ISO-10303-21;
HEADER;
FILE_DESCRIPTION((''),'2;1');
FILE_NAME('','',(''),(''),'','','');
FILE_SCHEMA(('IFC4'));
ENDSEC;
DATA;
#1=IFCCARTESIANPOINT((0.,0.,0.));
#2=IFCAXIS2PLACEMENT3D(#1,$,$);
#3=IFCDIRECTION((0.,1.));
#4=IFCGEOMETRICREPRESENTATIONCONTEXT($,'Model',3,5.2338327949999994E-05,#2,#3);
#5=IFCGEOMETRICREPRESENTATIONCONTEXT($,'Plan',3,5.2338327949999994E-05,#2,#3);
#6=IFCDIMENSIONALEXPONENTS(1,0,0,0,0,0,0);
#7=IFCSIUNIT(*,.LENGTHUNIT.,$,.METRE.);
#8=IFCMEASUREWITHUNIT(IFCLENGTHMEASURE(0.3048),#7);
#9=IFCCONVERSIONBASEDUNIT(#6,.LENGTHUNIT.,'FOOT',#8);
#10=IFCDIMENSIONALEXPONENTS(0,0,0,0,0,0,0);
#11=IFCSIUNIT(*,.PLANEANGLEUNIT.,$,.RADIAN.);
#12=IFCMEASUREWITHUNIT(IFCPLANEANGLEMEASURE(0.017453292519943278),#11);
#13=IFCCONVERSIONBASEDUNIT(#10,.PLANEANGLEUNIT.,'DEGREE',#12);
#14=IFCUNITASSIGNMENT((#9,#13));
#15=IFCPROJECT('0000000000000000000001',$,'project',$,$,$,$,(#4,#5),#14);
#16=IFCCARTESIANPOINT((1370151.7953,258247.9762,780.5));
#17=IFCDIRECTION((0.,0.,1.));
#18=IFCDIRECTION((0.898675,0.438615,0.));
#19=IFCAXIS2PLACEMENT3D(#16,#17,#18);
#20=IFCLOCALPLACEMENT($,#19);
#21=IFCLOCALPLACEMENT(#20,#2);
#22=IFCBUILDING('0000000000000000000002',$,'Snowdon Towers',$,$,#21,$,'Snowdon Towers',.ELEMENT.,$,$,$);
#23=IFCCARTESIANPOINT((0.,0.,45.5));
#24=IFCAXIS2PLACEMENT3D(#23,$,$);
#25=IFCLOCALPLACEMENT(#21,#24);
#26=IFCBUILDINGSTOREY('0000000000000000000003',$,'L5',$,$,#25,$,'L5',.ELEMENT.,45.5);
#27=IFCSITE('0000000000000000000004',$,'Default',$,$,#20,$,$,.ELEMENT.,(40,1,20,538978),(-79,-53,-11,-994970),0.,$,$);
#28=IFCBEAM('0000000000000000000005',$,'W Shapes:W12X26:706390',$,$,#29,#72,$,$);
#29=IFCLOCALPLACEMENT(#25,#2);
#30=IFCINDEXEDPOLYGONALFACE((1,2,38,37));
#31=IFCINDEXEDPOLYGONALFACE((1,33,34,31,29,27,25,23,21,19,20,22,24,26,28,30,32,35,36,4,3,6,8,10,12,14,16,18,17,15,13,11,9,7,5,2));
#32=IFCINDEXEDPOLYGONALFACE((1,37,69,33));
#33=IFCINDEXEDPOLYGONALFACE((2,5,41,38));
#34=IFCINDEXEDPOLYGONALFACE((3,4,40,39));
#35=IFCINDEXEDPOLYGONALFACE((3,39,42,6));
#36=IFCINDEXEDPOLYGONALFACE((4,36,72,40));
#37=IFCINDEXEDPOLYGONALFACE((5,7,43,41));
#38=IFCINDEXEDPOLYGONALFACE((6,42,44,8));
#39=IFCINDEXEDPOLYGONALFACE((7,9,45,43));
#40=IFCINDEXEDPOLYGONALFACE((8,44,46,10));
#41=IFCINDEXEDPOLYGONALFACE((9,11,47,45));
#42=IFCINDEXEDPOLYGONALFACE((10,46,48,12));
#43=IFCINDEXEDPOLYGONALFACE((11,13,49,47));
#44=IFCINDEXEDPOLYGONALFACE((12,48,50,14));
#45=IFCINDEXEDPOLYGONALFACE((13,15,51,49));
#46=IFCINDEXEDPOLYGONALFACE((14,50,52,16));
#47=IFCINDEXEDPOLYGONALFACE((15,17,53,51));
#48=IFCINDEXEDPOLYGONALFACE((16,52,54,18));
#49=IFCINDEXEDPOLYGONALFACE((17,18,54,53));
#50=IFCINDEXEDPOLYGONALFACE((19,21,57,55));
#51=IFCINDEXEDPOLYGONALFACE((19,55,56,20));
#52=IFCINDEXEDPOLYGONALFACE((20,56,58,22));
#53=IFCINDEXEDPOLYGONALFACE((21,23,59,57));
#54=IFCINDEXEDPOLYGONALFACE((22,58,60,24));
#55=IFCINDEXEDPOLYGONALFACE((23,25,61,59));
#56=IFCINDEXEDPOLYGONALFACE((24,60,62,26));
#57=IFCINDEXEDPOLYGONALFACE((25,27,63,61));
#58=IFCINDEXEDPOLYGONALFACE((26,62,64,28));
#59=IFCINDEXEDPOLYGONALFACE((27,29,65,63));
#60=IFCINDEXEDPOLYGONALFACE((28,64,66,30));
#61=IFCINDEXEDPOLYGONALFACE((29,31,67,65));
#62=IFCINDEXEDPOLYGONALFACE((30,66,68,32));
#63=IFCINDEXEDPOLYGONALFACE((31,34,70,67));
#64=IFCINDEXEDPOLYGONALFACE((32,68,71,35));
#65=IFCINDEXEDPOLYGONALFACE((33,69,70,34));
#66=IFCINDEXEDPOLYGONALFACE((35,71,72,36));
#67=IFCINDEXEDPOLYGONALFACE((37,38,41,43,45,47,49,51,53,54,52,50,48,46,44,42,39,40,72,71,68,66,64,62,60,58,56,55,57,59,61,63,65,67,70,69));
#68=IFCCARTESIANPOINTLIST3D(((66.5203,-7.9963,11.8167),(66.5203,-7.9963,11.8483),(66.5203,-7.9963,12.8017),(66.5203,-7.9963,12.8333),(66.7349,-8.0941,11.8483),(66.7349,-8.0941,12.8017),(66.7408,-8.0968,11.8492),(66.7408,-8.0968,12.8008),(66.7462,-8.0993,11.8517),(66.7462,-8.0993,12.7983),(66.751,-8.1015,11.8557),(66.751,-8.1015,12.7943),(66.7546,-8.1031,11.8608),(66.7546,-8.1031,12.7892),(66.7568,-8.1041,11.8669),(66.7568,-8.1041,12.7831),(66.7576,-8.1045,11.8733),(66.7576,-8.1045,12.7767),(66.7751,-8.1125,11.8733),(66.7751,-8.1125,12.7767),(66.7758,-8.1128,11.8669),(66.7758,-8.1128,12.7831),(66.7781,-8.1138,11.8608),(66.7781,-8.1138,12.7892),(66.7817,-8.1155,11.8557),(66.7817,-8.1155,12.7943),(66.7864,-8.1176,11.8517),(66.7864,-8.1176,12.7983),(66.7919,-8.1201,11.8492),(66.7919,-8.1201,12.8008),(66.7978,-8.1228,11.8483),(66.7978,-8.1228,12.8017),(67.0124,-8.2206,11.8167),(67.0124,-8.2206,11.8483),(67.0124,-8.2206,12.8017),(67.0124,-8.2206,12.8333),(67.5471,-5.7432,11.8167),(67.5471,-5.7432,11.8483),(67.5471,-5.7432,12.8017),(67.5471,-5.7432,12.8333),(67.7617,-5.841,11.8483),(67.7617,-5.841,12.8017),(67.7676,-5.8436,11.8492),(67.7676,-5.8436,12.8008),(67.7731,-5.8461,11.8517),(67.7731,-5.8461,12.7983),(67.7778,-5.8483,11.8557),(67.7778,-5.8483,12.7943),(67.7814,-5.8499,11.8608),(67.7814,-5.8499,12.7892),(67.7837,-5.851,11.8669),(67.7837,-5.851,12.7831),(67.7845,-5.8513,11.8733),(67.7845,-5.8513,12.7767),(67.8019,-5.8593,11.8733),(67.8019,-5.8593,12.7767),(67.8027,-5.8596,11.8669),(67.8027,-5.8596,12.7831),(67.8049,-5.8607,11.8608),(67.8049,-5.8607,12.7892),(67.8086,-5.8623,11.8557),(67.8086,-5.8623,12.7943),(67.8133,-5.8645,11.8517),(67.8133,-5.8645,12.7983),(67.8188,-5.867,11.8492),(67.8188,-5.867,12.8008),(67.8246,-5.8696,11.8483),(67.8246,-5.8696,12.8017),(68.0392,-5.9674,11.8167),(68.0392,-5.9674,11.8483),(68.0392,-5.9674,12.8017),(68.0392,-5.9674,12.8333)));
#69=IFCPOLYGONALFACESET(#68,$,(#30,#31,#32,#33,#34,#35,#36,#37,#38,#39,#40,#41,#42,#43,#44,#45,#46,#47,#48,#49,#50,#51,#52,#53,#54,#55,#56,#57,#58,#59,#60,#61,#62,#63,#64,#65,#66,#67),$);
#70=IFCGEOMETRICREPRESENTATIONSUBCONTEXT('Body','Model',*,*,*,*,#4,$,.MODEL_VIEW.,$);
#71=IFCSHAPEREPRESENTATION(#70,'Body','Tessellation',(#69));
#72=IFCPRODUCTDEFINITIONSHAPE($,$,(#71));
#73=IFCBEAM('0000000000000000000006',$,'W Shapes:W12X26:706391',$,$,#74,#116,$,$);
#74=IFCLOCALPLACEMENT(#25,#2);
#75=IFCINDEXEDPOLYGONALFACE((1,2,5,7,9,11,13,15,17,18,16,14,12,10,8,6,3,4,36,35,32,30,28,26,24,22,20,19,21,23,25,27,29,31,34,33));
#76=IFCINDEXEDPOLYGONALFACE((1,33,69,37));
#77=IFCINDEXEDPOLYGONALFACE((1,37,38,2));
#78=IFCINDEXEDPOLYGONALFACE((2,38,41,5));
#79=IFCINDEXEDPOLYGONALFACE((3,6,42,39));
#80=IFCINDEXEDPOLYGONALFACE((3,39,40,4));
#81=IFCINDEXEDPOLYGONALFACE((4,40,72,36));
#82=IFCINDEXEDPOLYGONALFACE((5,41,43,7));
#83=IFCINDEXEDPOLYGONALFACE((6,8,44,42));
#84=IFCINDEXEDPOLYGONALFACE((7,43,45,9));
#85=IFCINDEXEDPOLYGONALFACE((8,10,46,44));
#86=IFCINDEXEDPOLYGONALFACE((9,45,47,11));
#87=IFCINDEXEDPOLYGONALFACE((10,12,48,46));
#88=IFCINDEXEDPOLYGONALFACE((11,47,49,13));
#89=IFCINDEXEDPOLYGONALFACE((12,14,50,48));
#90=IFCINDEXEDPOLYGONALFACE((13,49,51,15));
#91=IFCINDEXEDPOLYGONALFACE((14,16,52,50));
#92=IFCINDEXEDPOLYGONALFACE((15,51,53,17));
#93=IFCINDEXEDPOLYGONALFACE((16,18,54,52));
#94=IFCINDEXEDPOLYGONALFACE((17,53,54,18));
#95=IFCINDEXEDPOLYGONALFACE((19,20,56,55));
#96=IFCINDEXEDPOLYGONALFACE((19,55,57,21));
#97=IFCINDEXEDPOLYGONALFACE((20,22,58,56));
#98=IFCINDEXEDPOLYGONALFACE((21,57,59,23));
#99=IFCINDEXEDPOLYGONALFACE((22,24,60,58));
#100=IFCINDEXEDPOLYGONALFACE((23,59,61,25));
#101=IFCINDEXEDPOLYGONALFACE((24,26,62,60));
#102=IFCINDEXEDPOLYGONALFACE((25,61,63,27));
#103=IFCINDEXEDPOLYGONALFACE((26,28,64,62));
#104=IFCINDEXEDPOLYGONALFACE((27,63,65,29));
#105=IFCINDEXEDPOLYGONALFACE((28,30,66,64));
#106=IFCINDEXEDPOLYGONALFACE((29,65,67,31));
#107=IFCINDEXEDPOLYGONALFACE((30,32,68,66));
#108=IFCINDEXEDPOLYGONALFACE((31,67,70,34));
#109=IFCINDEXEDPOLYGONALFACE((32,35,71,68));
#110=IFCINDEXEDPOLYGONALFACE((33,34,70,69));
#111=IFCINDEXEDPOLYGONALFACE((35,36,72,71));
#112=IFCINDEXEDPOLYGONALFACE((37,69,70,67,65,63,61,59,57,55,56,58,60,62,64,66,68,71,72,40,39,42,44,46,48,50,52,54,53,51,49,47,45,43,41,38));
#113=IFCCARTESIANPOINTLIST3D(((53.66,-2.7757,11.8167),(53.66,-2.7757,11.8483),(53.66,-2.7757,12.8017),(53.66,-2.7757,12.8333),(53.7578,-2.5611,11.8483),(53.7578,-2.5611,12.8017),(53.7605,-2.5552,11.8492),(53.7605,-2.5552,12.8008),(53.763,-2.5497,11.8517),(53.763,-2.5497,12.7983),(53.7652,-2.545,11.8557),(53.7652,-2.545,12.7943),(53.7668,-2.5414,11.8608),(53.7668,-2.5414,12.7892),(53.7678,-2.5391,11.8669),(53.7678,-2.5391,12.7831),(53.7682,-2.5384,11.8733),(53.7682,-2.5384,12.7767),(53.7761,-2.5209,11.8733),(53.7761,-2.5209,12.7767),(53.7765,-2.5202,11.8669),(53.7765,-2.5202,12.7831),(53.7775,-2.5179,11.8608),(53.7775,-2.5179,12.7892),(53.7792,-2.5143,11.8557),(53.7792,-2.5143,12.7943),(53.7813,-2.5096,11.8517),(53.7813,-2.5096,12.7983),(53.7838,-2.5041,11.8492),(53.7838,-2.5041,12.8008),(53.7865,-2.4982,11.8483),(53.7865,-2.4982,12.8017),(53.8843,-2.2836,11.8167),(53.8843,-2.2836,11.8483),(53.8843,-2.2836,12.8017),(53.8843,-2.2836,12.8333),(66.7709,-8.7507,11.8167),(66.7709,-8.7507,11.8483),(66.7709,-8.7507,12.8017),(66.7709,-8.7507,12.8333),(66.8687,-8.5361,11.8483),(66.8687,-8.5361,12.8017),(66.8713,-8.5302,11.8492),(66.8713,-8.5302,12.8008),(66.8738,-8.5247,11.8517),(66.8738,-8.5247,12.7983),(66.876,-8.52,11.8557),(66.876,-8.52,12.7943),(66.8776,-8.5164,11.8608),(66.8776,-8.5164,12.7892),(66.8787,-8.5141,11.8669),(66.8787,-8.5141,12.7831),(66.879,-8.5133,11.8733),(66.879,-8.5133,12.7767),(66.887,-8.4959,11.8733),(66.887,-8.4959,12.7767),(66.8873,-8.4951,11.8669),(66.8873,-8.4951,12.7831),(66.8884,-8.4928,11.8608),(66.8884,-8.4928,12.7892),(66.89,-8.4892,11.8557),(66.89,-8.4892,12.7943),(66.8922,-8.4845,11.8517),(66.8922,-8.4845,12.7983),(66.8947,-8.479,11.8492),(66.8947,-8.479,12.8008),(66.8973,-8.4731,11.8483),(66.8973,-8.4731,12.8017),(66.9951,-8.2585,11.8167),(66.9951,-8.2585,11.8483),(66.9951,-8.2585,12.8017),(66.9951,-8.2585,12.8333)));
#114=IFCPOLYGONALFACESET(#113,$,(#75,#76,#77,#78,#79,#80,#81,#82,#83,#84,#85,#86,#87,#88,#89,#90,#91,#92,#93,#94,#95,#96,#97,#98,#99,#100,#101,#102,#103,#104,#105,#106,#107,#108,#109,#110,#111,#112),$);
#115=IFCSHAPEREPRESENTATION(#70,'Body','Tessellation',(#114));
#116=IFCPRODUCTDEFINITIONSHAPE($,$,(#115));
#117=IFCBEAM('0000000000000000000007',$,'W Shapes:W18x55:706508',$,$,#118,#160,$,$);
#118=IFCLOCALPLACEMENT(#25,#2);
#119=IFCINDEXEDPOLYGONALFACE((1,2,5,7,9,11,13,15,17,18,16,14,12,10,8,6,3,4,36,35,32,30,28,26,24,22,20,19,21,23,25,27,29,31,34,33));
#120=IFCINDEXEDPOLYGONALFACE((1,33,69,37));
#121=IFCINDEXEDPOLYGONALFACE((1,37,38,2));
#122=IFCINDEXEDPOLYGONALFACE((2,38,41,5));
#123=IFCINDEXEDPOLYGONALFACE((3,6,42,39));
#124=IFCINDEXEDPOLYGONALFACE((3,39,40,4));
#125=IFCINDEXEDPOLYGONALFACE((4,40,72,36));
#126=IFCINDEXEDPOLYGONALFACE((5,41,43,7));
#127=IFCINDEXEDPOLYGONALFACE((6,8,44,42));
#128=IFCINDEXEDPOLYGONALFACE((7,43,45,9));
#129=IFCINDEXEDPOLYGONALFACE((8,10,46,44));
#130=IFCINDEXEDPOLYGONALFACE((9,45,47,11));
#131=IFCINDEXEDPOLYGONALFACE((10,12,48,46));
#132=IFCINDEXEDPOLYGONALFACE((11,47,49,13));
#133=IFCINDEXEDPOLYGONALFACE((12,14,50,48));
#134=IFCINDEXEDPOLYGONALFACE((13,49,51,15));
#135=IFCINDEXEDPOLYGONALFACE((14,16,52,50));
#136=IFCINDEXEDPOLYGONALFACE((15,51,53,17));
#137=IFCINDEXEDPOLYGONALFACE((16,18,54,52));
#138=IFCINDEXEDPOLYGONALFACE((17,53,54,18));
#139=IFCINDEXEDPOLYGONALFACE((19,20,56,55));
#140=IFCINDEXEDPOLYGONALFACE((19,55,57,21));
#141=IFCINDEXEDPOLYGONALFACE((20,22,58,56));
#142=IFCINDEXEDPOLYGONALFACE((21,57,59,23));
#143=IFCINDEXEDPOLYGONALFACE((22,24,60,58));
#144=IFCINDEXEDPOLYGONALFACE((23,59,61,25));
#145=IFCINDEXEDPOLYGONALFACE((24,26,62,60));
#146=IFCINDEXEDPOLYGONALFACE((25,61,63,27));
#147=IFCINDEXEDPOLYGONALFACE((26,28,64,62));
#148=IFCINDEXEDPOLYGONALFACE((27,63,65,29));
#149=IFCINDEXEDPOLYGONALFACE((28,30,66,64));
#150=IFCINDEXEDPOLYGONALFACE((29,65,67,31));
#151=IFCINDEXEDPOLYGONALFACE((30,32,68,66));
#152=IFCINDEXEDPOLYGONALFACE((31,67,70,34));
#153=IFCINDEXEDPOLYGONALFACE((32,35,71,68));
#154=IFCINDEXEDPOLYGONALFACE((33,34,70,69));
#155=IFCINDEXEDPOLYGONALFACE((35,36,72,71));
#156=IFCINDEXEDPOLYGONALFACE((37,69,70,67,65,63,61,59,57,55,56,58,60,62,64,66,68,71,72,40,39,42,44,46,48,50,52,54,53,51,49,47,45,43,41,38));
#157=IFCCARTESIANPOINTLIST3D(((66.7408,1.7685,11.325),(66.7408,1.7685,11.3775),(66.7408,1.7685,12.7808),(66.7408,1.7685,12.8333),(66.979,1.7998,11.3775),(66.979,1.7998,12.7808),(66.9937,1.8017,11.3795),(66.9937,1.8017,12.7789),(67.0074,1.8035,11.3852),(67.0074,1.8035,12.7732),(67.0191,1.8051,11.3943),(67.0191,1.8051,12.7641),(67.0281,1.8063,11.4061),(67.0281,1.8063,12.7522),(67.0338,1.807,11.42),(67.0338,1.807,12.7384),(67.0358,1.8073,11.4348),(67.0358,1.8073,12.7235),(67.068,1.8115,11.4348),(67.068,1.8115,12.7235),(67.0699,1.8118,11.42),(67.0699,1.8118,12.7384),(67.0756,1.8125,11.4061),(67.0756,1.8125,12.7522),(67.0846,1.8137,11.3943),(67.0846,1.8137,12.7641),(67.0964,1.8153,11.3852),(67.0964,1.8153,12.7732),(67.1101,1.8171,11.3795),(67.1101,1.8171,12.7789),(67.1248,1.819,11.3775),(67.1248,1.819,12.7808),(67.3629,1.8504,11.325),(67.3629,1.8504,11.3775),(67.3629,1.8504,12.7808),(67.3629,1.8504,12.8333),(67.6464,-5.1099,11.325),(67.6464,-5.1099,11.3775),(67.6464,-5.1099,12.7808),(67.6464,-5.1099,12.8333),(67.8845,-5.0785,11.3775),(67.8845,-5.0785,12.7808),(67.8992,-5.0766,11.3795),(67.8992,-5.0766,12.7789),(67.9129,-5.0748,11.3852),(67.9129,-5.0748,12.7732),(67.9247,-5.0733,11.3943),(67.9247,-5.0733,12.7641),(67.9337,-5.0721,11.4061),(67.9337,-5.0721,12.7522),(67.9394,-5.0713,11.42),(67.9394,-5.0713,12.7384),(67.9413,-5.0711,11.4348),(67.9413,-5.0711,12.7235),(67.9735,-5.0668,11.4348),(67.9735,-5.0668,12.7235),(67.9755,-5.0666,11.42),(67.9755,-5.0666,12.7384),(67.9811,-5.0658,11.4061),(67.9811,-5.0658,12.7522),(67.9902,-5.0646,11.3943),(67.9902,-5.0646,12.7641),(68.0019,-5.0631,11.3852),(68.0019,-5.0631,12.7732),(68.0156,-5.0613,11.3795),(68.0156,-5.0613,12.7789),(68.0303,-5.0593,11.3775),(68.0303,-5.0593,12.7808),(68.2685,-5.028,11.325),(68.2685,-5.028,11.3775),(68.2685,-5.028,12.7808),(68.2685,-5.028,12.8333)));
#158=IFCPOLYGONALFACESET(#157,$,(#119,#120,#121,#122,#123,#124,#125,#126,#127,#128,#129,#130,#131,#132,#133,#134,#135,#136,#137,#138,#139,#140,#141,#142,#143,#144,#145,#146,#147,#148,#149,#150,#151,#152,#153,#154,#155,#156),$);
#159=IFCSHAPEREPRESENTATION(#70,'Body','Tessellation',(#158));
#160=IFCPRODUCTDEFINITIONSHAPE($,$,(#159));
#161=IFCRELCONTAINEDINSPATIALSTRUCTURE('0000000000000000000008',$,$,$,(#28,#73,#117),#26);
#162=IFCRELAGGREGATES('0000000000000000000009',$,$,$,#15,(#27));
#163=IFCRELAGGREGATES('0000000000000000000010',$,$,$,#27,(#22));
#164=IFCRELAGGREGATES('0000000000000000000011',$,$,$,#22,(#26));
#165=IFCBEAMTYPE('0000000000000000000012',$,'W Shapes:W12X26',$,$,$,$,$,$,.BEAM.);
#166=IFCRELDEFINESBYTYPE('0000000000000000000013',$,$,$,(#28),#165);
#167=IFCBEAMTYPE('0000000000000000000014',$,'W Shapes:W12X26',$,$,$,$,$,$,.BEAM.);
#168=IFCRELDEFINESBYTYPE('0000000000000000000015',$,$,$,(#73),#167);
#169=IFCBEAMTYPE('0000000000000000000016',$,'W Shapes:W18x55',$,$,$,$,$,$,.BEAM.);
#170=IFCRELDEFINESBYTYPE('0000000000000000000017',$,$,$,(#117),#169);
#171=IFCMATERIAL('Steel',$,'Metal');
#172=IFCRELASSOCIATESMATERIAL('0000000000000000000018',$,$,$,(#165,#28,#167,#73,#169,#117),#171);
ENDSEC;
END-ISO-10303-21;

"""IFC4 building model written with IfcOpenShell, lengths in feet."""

from ifc_helpers import new_model, entity, si_unit, converted_unit, direction, frame, origin, place, context, subcontext, project, spatial, line, arc, indexed_curve, outline, extrude, source, transform, mapped, material, type_object, type_shapes, element, save


model = new_model("IFC4")

# Units and contexts
model_context = context("Model", 3, precision=5.2338327949999994e-05, world=origin(), true_north=direction((0.0, 1.0)))
plan_context = context("Plan", 3, precision=5.2338327949999994e-05, world=origin(), true_north=direction((0.0, 1.0)))
body_context = subcontext(model_context, "Body", "Model", "MODEL_VIEW")
ifc_project = project(units=[converted_unit("LENGTHUNIT", "FOOT", entity("IfcLengthMeasure", 0.3048), si_unit("LENGTHUNIT", "METRE"), dimensions=[1, 0, 0, 0, 0, 0, 0]), converted_unit("PLANEANGLEUNIT", "DEGREE", entity("IfcPlaneAngleMeasure", 0.017453292519943278), si_unit("PLANEANGLEUNIT", "RADIAN"), dimensions=[0, 0, 0, 0, 0, 0, 0])], contexts=[model_context, plan_context])

# Site, building, storey
site_placement = place(None, frame((1370151.7953, 258247.9762, 780.5), z_axis=(0.0, 0.0, 1.0), x_axis=(0.898675, 0.438615, 0.0)))
site = spatial("IfcSite", under=ifc_project, at=site_placement, Name="Default", CompositionType="ELEMENT", RefLatitude=(40, 1, 20, 538978), RefLongitude=(-79, -53, -11, -994970), RefElevation=0.0)
building_placement = place(site_placement, origin())
building = spatial("IfcBuilding", under=site, at=building_placement, Name="Snowdon Towers", LongName="Snowdon Towers", CompositionType="ELEMENT")
storey_placement = place(building_placement, frame((0.0, 0.0, 45.5)))
storey = spatial("IfcBuildingStorey", under=building, at=storey_placement, Name="L5", LongName="L5", CompositionType="ELEMENT", Elevation=45.5)

# Shared definitions
ifc_material = material(Name="Steel", Category="Metal")

# Beams
beam_type_1 = type_object("IfcBeamType", Name="W Shapes:W12X26", PredefinedType="BEAM", material=ifc_material)
shared_shape_1 = source(origin(), body_context, "Body", "SweptSolid", [
    extrude(outline(indexed_curve([(-0.5083, -0.2704), (-0.4767, -0.2704), (-0.4767, -0.0346), (-0.4693, -0.0169), (-0.4517, -0.0096), (0.4517, -0.0096), (0.4693, -0.0169), (0.4767, -0.0346), (0.4767, -0.2704), (0.5083, -0.2704), (0.5083, 0.2704), (0.4767, 0.2704), (0.4767, 0.0346), (0.4693, 0.0169), (0.4517, 0.0096), (-0.4517, 0.0096), (-0.4693, 0.0169), (-0.4767, 0.0346), (-0.4767, 0.2704), (-0.5083, 0.2704)], segments=[line(1, 2, 3), arc(3, 4, 5), line(5, 6), arc(6, 7, 8), line(8, 9, 10, 11, 12, 13), arc(13, 14, 15), line(15, 16), arc(16, 17, 18), line(18, 19, 20, 1)], self_intersect=False)), frame((-1.3325, 0.0, 0.0), z_axis=(1.0, 0.0, 0.0), x_axis=(0.0, 0.0, -1.0)), (0.0, 0.0, 1.0), 2.4761),
])
type_shapes(beam_type_1, [shared_shape_1])
beam_1_placement = place(storey_placement, frame((67.3189, -6.8959, 12.325), z_axis=(0.0, 0.0, 1.0), x_axis=(0.414693, 0.909961, 0.0)))
element("IfcBeam", 1, at=beam_1_placement, inside=storey, type_object=beam_type_1, material=ifc_material, Name="W Shapes:W12X26:706390", context=body_context, shape_type="MappedRepresentation", body=[
    mapped(shared_shape_1, transform((0.0, 0.0, 0.0), scale=1.0)),
])
beam_type_2 = type_object("IfcBeamType", Name="W Shapes:W12X26", PredefinedType="BEAM", material=ifc_material)
shared_shape_2 = source(origin(), body_context, "Body", "SweptSolid", [
    extrude(outline(indexed_curve([(-0.5083, -0.2704), (-0.4767, -0.2704), (-0.4767, -0.0346), (-0.4693, -0.0169), (-0.4517, -0.0096), (0.4517, -0.0096), (0.4693, -0.0169), (0.4767, -0.0346), (0.4767, -0.2704), (0.5083, -0.2704), (0.5083, 0.2704), (0.4767, 0.2704), (0.4767, 0.0346), (0.4693, 0.0169), (0.4517, 0.0096), (-0.4517, 0.0096), (-0.4693, 0.0169), (-0.4767, 0.0346), (-0.4767, 0.2704), (-0.5083, 0.2704)], segments=[line(1, 2, 3), arc(3, 4, 5), line(5, 6), arc(6, 7, 8), line(8, 9, 10, 11, 12, 13), arc(13, 14, 15), line(15, 16), arc(16, 17, 18), line(18, 19, 20, 1)], self_intersect=False)), frame((-7.0689, 0.0, 0.0), z_axis=(1.0, 0.0, 0.0), x_axis=(0.0, 0.0, -1.0)), (0.0, 0.0, 1.0), 14.4081),
])
type_shapes(beam_type_2, [shared_shape_2])
beam_2_placement = place(storey_placement, frame((60.2045, -5.4611, 12.325), z_axis=(0.0, 0.0, 1.0), x_axis=(0.909961, -0.414693, 0.0)))
element("IfcBeam", 2, at=beam_2_placement, inside=storey, type_object=beam_type_2, material=ifc_material, Name="W Shapes:W12X26:706391", context=body_context, shape_type="MappedRepresentation", body=[
    mapped(shared_shape_2, transform((0.0, 0.0, 0.0), scale=1.0)),
])
beam_type_3 = type_object("IfcBeamType", Name="W Shapes:W18x55", PredefinedType="BEAM", material=ifc_material)
shared_shape_3 = source(origin(), body_context, "Body", "SweptSolid", [
    extrude(outline(indexed_curve([(-0.7542, -0.3137), (-0.7017, -0.3137), (-0.7017, -0.0735), (-0.6849, -0.033), (-0.6444, -0.0162), (0.6444, -0.0163), (0.6849, -0.033), (0.7017, -0.0735), (0.7017, -0.3138), (0.7542, -0.3138), (0.7542, 0.3137), (0.7017, 0.3137), (0.7017, 0.0735), (0.6849, 0.033), (0.6444, 0.0162), (-0.6444, 0.0163), (-0.6849, 0.033), (-0.7017, 0.0735), (-0.7017, 0.3138), (-0.7542, 0.3138)], segments=[line(1, 2, 3), arc(3, 4, 5), line(5, 6), arc(6, 7, 8), line(8, 9, 10, 11, 12, 13), arc(13, 14, 15), line(15, 16), arc(16, 17, 18), line(18, 19, 20, 1)], self_intersect=False)), frame((-3.2872, 0.0, 0.0), z_axis=(1.0, 0.0, 0.0), x_axis=(0.0, 0.0, -1.0)), (0.0, 0.0, 1.0), 6.9377),
])
type_shapes(beam_type_3, [shared_shape_3])
beam_3_placement = place(storey_placement, frame((67.4809, -1.4497, 12.0792), z_axis=(0.0, 0.0, 1.0), x_axis=(0.130526, -0.991445, 0.0)))
element("IfcBeam", 3, at=beam_3_placement, inside=storey, type_object=beam_type_3, material=ifc_material, Name="W Shapes:W18x55:706508", context=body_context, shape_type="MappedRepresentation", body=[
    mapped(shared_shape_3, transform((0.0, 0.0, 0.0), scale=1.0)),
])

save(model, "model.ifc")
